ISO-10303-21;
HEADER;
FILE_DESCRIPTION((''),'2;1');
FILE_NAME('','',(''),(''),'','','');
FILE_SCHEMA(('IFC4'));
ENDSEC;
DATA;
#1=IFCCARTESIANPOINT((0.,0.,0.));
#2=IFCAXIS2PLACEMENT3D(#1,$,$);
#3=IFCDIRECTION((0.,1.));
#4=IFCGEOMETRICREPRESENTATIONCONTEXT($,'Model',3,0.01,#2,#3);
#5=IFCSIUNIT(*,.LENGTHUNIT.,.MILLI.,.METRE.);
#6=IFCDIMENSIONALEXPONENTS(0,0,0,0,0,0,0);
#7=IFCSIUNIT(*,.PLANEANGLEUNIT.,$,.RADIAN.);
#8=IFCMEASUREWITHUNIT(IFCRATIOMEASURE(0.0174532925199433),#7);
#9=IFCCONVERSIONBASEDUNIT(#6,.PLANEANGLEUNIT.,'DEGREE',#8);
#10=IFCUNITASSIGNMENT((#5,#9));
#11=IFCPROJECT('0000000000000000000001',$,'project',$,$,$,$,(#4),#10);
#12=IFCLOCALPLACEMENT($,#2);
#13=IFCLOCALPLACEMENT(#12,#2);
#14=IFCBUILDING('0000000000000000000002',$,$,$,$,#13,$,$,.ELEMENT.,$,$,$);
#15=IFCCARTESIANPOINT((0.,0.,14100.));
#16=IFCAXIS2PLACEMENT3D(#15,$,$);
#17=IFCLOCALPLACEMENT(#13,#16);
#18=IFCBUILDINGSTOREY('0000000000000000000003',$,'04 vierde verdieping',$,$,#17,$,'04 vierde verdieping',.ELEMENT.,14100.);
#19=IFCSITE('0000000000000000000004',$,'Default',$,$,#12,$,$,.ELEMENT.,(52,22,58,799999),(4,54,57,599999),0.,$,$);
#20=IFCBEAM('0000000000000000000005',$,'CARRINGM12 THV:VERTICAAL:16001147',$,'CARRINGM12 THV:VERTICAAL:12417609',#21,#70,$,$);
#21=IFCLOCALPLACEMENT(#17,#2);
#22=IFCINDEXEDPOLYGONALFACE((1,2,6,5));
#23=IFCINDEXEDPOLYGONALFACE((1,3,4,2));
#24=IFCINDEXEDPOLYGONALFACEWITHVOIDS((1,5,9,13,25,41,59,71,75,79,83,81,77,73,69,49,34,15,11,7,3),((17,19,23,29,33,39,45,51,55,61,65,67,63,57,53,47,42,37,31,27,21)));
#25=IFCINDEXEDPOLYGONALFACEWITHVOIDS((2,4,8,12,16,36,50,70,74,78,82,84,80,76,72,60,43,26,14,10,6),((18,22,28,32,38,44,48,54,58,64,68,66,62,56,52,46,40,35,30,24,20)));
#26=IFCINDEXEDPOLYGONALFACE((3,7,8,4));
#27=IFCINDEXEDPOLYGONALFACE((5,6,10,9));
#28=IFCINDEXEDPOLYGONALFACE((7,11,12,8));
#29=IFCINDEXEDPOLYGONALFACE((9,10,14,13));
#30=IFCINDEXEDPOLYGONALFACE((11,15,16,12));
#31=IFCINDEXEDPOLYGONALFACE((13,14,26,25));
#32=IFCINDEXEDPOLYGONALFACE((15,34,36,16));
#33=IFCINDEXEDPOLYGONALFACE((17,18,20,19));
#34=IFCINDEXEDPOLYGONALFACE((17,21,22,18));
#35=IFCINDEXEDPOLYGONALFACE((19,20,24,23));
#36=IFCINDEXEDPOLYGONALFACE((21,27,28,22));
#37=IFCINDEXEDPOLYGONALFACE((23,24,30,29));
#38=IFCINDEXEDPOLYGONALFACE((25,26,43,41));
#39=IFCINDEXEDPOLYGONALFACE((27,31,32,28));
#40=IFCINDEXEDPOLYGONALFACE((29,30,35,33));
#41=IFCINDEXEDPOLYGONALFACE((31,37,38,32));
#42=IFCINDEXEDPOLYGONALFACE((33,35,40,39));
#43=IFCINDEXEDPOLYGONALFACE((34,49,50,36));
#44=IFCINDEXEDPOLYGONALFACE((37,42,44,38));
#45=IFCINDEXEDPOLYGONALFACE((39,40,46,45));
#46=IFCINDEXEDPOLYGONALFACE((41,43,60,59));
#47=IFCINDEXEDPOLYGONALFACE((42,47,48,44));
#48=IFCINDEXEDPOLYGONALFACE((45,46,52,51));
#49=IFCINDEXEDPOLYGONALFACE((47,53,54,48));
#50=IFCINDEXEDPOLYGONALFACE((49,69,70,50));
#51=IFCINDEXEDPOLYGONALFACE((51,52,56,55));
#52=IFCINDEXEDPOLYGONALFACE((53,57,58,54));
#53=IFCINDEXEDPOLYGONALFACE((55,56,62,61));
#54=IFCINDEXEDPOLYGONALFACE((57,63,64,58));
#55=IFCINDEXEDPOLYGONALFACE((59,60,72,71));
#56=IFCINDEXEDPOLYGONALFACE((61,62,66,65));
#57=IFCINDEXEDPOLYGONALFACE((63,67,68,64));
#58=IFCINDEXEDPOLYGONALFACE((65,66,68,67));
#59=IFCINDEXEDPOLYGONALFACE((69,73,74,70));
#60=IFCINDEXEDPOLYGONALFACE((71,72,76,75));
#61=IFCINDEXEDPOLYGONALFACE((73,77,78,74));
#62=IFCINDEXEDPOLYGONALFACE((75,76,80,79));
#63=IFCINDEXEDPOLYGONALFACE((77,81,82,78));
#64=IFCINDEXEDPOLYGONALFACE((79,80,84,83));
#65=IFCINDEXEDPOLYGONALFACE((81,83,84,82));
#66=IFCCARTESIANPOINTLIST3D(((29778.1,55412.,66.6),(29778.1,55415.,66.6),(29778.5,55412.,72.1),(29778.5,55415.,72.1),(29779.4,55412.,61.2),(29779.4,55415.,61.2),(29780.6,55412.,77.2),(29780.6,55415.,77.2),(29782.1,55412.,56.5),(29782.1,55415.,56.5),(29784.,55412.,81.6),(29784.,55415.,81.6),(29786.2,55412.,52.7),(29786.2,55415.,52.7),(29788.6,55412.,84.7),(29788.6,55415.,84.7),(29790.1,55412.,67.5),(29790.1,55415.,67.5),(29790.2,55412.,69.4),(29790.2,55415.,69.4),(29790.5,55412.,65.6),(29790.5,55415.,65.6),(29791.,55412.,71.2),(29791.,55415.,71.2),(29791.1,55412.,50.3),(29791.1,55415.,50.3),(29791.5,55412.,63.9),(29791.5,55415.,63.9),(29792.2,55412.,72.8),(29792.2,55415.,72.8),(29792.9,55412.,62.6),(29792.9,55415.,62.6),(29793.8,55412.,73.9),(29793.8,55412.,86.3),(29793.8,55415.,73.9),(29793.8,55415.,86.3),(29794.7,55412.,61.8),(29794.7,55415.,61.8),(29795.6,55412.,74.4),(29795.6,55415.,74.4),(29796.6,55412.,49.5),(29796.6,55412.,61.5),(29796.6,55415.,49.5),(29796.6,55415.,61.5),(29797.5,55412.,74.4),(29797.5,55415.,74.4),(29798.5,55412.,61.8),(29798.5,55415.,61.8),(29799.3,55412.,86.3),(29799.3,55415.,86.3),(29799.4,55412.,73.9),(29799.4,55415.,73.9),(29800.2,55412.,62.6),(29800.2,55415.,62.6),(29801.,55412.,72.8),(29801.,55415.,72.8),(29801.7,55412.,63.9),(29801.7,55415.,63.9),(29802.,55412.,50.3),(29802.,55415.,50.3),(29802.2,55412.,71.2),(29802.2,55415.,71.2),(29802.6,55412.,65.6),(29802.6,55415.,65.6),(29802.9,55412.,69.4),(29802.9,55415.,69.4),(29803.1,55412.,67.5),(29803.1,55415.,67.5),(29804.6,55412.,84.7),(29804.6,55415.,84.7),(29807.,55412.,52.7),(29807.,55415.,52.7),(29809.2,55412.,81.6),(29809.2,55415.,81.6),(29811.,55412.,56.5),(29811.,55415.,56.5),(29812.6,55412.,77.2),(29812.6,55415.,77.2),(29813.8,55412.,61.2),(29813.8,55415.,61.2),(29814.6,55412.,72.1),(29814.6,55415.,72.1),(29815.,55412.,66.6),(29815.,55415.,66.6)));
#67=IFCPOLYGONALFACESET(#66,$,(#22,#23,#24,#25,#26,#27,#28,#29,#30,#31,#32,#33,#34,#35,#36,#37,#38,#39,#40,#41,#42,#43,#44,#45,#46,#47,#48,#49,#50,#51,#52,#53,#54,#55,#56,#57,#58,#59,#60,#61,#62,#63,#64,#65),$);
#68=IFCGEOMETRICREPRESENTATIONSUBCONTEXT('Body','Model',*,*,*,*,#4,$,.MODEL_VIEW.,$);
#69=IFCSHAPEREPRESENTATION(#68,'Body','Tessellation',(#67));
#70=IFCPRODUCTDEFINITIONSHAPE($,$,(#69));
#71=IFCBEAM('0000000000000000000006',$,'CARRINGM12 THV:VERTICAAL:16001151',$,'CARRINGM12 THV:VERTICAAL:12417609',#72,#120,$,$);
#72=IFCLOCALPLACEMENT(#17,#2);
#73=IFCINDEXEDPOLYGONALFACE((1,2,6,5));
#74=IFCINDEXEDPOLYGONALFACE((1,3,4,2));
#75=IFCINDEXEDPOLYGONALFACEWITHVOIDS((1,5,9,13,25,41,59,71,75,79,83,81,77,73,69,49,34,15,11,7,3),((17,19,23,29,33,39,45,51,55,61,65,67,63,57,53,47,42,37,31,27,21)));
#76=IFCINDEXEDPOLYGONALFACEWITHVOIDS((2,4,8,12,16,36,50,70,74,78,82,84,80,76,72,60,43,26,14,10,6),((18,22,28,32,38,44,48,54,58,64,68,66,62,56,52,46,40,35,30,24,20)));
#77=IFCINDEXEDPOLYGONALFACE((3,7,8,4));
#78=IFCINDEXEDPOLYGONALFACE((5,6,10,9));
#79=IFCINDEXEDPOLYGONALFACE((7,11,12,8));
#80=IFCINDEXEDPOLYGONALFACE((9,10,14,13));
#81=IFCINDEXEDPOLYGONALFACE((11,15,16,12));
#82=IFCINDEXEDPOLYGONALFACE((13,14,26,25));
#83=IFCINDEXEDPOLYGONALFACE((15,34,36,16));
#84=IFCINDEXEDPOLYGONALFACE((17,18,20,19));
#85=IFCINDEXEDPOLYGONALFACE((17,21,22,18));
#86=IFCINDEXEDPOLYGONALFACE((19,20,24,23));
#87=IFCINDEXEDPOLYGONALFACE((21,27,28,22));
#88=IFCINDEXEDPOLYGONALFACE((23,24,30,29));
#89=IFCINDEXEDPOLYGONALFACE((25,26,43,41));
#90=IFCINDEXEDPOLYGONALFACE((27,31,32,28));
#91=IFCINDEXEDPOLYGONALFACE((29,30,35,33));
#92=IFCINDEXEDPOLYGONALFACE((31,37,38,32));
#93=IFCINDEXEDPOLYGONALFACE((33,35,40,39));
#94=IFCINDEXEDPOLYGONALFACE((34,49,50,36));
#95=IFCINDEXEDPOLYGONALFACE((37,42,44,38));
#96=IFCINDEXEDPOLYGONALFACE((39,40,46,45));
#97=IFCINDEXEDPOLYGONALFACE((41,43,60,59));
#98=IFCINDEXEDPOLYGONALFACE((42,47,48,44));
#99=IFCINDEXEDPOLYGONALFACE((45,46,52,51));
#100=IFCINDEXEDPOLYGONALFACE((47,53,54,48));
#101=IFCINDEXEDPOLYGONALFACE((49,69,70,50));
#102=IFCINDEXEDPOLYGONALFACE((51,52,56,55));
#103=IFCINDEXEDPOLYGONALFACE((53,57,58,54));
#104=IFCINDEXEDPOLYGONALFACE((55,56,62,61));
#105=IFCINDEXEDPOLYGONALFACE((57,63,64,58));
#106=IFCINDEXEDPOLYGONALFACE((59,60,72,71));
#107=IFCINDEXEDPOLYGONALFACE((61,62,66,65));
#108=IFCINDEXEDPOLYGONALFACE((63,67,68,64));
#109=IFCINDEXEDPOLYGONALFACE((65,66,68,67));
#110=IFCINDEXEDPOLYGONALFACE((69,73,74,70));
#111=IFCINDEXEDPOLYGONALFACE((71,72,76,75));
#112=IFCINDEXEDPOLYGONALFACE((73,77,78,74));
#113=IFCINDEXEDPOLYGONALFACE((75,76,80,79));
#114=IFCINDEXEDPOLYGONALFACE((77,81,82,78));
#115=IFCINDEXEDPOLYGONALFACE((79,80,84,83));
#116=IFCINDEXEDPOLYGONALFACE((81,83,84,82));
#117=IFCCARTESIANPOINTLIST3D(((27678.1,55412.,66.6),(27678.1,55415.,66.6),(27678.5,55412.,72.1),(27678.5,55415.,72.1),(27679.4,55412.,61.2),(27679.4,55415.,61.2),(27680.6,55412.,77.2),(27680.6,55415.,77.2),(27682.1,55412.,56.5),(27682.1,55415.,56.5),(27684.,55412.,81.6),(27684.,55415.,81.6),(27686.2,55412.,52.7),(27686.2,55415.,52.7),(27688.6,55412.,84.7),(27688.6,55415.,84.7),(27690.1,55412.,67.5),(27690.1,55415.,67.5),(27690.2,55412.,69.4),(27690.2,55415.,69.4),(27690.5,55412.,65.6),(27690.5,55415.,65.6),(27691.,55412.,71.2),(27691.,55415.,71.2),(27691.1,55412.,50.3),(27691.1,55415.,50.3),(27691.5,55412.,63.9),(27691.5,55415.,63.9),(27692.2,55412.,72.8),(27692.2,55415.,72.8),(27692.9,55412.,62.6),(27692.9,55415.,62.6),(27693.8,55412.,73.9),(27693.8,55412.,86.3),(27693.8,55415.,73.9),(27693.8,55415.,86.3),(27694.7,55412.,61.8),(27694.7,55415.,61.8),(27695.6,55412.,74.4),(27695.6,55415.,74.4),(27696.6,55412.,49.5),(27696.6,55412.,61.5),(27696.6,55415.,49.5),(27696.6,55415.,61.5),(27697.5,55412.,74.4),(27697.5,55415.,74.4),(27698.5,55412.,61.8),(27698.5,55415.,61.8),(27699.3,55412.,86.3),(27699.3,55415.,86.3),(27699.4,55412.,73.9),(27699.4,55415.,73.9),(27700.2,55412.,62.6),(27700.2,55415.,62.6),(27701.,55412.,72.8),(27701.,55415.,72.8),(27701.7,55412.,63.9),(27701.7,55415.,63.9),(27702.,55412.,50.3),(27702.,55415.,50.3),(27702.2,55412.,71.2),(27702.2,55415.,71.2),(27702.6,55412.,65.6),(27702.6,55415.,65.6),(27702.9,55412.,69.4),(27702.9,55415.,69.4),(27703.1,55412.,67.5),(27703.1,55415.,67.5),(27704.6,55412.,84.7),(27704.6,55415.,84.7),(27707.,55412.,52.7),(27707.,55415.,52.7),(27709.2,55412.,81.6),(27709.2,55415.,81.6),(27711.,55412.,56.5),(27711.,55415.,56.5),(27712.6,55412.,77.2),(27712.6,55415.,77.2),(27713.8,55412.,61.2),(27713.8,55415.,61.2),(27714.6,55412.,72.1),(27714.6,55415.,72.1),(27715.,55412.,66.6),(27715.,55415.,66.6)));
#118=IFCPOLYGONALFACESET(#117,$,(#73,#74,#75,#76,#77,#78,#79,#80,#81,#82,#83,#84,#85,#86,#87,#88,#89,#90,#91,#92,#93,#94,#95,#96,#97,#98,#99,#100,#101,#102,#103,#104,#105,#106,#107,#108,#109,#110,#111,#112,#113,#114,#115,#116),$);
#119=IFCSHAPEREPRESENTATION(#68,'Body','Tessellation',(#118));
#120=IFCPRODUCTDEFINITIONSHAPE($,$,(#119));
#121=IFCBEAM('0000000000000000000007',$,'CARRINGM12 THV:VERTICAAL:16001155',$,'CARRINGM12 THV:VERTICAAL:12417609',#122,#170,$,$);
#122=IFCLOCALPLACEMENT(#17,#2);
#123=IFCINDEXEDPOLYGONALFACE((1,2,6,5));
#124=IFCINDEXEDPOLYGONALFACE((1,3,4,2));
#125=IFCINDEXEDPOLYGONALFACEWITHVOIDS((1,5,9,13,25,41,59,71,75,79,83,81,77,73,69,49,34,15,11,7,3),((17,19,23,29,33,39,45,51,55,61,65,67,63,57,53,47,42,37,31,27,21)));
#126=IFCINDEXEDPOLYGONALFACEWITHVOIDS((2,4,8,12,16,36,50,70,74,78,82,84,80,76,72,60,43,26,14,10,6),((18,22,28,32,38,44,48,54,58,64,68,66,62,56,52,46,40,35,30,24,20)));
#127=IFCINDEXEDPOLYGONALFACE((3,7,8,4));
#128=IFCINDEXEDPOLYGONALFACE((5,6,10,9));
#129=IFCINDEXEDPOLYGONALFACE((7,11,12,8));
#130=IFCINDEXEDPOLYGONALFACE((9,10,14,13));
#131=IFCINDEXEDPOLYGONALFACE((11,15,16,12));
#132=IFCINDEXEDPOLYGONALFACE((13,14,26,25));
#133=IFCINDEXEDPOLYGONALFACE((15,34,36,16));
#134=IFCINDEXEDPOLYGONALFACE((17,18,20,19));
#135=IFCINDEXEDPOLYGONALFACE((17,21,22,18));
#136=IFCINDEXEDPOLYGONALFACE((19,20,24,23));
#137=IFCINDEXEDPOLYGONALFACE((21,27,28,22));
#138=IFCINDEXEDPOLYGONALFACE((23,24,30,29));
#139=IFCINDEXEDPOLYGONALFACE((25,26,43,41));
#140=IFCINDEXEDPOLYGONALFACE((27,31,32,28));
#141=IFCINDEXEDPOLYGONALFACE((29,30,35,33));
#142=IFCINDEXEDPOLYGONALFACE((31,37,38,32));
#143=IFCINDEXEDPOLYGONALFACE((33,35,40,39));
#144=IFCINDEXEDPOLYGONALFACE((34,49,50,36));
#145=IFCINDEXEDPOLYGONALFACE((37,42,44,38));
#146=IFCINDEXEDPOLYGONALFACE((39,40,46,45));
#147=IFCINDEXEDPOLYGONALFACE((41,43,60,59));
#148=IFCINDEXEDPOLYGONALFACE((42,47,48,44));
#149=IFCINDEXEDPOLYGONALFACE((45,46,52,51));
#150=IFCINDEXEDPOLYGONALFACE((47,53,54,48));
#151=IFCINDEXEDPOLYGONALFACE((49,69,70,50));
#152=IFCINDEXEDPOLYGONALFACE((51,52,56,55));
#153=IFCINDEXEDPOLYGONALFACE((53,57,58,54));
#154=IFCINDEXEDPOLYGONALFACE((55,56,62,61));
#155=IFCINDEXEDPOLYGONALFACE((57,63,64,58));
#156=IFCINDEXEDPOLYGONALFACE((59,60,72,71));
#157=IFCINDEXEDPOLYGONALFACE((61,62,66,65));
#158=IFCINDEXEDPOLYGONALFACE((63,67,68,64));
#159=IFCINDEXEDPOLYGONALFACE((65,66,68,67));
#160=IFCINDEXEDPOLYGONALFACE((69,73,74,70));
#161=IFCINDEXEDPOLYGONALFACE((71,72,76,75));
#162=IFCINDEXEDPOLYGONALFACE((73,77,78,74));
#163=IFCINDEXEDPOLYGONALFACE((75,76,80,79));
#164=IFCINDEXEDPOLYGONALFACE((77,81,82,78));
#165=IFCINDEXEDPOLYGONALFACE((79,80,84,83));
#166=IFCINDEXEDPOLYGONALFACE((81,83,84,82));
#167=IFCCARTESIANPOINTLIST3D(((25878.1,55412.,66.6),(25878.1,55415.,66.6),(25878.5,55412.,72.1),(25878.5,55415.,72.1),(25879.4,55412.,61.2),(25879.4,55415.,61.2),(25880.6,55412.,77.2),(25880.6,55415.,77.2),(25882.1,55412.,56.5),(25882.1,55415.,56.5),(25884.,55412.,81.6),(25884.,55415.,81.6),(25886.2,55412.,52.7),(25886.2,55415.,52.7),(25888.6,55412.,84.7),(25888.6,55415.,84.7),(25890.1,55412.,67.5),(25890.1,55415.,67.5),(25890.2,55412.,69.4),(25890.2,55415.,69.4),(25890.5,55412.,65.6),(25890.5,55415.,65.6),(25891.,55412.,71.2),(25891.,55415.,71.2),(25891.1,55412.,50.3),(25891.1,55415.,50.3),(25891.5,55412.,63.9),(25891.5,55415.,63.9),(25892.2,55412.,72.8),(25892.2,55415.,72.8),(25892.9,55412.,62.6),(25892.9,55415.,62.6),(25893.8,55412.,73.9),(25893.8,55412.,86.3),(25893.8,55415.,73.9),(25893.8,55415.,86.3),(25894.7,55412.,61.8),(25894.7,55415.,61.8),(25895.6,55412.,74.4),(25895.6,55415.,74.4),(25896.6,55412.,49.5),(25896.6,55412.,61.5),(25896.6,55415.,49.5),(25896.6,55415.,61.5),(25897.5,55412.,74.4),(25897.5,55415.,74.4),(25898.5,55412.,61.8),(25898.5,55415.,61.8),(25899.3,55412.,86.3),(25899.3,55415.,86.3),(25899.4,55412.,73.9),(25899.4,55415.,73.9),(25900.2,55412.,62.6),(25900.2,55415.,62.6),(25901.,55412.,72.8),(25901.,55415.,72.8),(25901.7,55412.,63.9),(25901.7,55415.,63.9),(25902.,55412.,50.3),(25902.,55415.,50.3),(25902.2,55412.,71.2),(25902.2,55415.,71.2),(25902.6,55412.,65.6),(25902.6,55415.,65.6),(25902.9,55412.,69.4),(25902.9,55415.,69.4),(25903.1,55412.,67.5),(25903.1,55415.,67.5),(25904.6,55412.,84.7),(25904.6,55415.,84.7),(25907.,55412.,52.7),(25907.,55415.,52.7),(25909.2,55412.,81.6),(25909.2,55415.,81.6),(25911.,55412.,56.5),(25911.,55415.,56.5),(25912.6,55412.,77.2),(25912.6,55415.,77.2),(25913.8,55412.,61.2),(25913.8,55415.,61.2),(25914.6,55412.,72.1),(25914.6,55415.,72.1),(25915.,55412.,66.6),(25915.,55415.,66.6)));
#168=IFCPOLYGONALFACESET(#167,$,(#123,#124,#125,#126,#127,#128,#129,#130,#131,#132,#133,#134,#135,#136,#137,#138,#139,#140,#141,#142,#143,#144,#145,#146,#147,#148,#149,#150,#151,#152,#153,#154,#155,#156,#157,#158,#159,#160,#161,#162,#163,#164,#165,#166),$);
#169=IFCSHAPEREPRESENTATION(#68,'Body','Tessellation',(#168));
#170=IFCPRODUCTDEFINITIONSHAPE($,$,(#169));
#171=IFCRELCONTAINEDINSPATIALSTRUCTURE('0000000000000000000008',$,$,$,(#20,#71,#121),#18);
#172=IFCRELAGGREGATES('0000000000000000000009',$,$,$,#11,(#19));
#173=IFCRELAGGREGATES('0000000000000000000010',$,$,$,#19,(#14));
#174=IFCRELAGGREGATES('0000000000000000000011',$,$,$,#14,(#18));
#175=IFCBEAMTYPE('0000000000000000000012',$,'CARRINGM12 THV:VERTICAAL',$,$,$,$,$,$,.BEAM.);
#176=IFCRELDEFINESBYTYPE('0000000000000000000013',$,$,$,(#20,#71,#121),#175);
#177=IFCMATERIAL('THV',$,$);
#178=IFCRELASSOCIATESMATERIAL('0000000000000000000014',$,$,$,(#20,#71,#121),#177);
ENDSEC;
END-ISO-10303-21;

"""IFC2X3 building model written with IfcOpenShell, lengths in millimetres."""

from ifc_helpers import new_model, entity, si_unit, converted_unit, direction, frame, origin, origin_2d_with_axis, place, context, subcontext, project, spatial, hollow_circle, extrude, material, type_object, element, save


model = new_model("IFC2X3")

# Units and contexts
model_context = context("Model", 3, precision=0.01, world=origin(), true_north=direction((0.0, 1.0)))
body_context = subcontext(model_context, "Body", "Model", "MODEL_VIEW")
ifc_project = project(units=[si_unit("LENGTHUNIT", "METRE", prefix="MILLI"), converted_unit("PLANEANGLEUNIT", "DEGREE", entity("IfcRatioMeasure", 0.0174532925199433), si_unit("PLANEANGLEUNIT", "RADIAN"), dimensions=[0, 0, 0, 0, 0, 0, 0])], contexts=[model_context])

# Site, building, storey
site_placement = place(None, origin())
site = spatial("IfcSite", under=ifc_project, at=site_placement, Name="Default", CompositionType="ELEMENT", RefLatitude=(52, 22, 58, 799999), RefLongitude=(4, 54, 57, 599999), RefElevation=0.0)
building_placement = place(site_placement, origin())
building = spatial("IfcBuilding", under=site, at=building_placement, CompositionType="ELEMENT")
storey_placement = place(building_placement, frame((0.0, 0.0, 14100.0)))
storey = spatial("IfcBuildingStorey", under=building, at=storey_placement, Name="04 vierde verdieping", LongName="04 vierde verdieping", CompositionType="ELEMENT", Elevation=14100.0)

# Beams
ifc_material_1 = material(Name="THV")
beam_type_1 = type_object("IfcBeamType", Name="CARRINGM12 THV:VERTICAAL", PredefinedType="BEAM")
beam_1_placement = place(storey_placement, origin())
element("IfcBeam", 1, at=beam_1_placement, inside=storey, type_object=beam_type_1, material=ifc_material_1, Name="CARRINGM12 THV:VERTICAAL:16001147", ObjectType="CARRINGM12 THV:VERTICAAL:12417609", context=body_context, shape_type="SweptSolid", body=[
    extrude(hollow_circle(Radius=18.5, WallThickness=12.0, at=origin_2d_with_axis()), frame((29796.6, 55412.0, 68.0), z_axis=(0.0, 1.0, 0.0), x_axis=(0.0, 0.0, -1.0)), (0.0, 0.0, 1.0), 3.0),
])
beam_2_placement = place(storey_placement, origin())
element("IfcBeam", 2, at=beam_2_placement, inside=storey, type_object=beam_type_1, material=ifc_material_1, Name="CARRINGM12 THV:VERTICAAL:16001151", ObjectType="CARRINGM12 THV:VERTICAAL:12417609", context=body_context, shape_type="SweptSolid", body=[
    extrude(hollow_circle(Radius=18.5, WallThickness=12.0, at=origin_2d_with_axis()), frame((27696.6, 55412.0, 68.0), z_axis=(0.0, 1.0, 0.0), x_axis=(0.0, 0.0, -1.0)), (0.0, 0.0, 1.0), 3.0),
])
beam_3_placement = place(storey_placement, origin())
element("IfcBeam", 3, at=beam_3_placement, inside=storey, type_object=beam_type_1, material=ifc_material_1, Name="CARRINGM12 THV:VERTICAAL:16001155", ObjectType="CARRINGM12 THV:VERTICAAL:12417609", context=body_context, shape_type="SweptSolid", body=[
    extrude(hollow_circle(Radius=18.5, WallThickness=12.0, at=origin_2d_with_axis()), frame((25896.6, 55412.0, 68.0), z_axis=(0.0, 1.0, 0.0), x_axis=(0.0, 0.0, -1.0)), (0.0, 0.0, 1.0), 3.0),
])

save(model, "model.ifc")
